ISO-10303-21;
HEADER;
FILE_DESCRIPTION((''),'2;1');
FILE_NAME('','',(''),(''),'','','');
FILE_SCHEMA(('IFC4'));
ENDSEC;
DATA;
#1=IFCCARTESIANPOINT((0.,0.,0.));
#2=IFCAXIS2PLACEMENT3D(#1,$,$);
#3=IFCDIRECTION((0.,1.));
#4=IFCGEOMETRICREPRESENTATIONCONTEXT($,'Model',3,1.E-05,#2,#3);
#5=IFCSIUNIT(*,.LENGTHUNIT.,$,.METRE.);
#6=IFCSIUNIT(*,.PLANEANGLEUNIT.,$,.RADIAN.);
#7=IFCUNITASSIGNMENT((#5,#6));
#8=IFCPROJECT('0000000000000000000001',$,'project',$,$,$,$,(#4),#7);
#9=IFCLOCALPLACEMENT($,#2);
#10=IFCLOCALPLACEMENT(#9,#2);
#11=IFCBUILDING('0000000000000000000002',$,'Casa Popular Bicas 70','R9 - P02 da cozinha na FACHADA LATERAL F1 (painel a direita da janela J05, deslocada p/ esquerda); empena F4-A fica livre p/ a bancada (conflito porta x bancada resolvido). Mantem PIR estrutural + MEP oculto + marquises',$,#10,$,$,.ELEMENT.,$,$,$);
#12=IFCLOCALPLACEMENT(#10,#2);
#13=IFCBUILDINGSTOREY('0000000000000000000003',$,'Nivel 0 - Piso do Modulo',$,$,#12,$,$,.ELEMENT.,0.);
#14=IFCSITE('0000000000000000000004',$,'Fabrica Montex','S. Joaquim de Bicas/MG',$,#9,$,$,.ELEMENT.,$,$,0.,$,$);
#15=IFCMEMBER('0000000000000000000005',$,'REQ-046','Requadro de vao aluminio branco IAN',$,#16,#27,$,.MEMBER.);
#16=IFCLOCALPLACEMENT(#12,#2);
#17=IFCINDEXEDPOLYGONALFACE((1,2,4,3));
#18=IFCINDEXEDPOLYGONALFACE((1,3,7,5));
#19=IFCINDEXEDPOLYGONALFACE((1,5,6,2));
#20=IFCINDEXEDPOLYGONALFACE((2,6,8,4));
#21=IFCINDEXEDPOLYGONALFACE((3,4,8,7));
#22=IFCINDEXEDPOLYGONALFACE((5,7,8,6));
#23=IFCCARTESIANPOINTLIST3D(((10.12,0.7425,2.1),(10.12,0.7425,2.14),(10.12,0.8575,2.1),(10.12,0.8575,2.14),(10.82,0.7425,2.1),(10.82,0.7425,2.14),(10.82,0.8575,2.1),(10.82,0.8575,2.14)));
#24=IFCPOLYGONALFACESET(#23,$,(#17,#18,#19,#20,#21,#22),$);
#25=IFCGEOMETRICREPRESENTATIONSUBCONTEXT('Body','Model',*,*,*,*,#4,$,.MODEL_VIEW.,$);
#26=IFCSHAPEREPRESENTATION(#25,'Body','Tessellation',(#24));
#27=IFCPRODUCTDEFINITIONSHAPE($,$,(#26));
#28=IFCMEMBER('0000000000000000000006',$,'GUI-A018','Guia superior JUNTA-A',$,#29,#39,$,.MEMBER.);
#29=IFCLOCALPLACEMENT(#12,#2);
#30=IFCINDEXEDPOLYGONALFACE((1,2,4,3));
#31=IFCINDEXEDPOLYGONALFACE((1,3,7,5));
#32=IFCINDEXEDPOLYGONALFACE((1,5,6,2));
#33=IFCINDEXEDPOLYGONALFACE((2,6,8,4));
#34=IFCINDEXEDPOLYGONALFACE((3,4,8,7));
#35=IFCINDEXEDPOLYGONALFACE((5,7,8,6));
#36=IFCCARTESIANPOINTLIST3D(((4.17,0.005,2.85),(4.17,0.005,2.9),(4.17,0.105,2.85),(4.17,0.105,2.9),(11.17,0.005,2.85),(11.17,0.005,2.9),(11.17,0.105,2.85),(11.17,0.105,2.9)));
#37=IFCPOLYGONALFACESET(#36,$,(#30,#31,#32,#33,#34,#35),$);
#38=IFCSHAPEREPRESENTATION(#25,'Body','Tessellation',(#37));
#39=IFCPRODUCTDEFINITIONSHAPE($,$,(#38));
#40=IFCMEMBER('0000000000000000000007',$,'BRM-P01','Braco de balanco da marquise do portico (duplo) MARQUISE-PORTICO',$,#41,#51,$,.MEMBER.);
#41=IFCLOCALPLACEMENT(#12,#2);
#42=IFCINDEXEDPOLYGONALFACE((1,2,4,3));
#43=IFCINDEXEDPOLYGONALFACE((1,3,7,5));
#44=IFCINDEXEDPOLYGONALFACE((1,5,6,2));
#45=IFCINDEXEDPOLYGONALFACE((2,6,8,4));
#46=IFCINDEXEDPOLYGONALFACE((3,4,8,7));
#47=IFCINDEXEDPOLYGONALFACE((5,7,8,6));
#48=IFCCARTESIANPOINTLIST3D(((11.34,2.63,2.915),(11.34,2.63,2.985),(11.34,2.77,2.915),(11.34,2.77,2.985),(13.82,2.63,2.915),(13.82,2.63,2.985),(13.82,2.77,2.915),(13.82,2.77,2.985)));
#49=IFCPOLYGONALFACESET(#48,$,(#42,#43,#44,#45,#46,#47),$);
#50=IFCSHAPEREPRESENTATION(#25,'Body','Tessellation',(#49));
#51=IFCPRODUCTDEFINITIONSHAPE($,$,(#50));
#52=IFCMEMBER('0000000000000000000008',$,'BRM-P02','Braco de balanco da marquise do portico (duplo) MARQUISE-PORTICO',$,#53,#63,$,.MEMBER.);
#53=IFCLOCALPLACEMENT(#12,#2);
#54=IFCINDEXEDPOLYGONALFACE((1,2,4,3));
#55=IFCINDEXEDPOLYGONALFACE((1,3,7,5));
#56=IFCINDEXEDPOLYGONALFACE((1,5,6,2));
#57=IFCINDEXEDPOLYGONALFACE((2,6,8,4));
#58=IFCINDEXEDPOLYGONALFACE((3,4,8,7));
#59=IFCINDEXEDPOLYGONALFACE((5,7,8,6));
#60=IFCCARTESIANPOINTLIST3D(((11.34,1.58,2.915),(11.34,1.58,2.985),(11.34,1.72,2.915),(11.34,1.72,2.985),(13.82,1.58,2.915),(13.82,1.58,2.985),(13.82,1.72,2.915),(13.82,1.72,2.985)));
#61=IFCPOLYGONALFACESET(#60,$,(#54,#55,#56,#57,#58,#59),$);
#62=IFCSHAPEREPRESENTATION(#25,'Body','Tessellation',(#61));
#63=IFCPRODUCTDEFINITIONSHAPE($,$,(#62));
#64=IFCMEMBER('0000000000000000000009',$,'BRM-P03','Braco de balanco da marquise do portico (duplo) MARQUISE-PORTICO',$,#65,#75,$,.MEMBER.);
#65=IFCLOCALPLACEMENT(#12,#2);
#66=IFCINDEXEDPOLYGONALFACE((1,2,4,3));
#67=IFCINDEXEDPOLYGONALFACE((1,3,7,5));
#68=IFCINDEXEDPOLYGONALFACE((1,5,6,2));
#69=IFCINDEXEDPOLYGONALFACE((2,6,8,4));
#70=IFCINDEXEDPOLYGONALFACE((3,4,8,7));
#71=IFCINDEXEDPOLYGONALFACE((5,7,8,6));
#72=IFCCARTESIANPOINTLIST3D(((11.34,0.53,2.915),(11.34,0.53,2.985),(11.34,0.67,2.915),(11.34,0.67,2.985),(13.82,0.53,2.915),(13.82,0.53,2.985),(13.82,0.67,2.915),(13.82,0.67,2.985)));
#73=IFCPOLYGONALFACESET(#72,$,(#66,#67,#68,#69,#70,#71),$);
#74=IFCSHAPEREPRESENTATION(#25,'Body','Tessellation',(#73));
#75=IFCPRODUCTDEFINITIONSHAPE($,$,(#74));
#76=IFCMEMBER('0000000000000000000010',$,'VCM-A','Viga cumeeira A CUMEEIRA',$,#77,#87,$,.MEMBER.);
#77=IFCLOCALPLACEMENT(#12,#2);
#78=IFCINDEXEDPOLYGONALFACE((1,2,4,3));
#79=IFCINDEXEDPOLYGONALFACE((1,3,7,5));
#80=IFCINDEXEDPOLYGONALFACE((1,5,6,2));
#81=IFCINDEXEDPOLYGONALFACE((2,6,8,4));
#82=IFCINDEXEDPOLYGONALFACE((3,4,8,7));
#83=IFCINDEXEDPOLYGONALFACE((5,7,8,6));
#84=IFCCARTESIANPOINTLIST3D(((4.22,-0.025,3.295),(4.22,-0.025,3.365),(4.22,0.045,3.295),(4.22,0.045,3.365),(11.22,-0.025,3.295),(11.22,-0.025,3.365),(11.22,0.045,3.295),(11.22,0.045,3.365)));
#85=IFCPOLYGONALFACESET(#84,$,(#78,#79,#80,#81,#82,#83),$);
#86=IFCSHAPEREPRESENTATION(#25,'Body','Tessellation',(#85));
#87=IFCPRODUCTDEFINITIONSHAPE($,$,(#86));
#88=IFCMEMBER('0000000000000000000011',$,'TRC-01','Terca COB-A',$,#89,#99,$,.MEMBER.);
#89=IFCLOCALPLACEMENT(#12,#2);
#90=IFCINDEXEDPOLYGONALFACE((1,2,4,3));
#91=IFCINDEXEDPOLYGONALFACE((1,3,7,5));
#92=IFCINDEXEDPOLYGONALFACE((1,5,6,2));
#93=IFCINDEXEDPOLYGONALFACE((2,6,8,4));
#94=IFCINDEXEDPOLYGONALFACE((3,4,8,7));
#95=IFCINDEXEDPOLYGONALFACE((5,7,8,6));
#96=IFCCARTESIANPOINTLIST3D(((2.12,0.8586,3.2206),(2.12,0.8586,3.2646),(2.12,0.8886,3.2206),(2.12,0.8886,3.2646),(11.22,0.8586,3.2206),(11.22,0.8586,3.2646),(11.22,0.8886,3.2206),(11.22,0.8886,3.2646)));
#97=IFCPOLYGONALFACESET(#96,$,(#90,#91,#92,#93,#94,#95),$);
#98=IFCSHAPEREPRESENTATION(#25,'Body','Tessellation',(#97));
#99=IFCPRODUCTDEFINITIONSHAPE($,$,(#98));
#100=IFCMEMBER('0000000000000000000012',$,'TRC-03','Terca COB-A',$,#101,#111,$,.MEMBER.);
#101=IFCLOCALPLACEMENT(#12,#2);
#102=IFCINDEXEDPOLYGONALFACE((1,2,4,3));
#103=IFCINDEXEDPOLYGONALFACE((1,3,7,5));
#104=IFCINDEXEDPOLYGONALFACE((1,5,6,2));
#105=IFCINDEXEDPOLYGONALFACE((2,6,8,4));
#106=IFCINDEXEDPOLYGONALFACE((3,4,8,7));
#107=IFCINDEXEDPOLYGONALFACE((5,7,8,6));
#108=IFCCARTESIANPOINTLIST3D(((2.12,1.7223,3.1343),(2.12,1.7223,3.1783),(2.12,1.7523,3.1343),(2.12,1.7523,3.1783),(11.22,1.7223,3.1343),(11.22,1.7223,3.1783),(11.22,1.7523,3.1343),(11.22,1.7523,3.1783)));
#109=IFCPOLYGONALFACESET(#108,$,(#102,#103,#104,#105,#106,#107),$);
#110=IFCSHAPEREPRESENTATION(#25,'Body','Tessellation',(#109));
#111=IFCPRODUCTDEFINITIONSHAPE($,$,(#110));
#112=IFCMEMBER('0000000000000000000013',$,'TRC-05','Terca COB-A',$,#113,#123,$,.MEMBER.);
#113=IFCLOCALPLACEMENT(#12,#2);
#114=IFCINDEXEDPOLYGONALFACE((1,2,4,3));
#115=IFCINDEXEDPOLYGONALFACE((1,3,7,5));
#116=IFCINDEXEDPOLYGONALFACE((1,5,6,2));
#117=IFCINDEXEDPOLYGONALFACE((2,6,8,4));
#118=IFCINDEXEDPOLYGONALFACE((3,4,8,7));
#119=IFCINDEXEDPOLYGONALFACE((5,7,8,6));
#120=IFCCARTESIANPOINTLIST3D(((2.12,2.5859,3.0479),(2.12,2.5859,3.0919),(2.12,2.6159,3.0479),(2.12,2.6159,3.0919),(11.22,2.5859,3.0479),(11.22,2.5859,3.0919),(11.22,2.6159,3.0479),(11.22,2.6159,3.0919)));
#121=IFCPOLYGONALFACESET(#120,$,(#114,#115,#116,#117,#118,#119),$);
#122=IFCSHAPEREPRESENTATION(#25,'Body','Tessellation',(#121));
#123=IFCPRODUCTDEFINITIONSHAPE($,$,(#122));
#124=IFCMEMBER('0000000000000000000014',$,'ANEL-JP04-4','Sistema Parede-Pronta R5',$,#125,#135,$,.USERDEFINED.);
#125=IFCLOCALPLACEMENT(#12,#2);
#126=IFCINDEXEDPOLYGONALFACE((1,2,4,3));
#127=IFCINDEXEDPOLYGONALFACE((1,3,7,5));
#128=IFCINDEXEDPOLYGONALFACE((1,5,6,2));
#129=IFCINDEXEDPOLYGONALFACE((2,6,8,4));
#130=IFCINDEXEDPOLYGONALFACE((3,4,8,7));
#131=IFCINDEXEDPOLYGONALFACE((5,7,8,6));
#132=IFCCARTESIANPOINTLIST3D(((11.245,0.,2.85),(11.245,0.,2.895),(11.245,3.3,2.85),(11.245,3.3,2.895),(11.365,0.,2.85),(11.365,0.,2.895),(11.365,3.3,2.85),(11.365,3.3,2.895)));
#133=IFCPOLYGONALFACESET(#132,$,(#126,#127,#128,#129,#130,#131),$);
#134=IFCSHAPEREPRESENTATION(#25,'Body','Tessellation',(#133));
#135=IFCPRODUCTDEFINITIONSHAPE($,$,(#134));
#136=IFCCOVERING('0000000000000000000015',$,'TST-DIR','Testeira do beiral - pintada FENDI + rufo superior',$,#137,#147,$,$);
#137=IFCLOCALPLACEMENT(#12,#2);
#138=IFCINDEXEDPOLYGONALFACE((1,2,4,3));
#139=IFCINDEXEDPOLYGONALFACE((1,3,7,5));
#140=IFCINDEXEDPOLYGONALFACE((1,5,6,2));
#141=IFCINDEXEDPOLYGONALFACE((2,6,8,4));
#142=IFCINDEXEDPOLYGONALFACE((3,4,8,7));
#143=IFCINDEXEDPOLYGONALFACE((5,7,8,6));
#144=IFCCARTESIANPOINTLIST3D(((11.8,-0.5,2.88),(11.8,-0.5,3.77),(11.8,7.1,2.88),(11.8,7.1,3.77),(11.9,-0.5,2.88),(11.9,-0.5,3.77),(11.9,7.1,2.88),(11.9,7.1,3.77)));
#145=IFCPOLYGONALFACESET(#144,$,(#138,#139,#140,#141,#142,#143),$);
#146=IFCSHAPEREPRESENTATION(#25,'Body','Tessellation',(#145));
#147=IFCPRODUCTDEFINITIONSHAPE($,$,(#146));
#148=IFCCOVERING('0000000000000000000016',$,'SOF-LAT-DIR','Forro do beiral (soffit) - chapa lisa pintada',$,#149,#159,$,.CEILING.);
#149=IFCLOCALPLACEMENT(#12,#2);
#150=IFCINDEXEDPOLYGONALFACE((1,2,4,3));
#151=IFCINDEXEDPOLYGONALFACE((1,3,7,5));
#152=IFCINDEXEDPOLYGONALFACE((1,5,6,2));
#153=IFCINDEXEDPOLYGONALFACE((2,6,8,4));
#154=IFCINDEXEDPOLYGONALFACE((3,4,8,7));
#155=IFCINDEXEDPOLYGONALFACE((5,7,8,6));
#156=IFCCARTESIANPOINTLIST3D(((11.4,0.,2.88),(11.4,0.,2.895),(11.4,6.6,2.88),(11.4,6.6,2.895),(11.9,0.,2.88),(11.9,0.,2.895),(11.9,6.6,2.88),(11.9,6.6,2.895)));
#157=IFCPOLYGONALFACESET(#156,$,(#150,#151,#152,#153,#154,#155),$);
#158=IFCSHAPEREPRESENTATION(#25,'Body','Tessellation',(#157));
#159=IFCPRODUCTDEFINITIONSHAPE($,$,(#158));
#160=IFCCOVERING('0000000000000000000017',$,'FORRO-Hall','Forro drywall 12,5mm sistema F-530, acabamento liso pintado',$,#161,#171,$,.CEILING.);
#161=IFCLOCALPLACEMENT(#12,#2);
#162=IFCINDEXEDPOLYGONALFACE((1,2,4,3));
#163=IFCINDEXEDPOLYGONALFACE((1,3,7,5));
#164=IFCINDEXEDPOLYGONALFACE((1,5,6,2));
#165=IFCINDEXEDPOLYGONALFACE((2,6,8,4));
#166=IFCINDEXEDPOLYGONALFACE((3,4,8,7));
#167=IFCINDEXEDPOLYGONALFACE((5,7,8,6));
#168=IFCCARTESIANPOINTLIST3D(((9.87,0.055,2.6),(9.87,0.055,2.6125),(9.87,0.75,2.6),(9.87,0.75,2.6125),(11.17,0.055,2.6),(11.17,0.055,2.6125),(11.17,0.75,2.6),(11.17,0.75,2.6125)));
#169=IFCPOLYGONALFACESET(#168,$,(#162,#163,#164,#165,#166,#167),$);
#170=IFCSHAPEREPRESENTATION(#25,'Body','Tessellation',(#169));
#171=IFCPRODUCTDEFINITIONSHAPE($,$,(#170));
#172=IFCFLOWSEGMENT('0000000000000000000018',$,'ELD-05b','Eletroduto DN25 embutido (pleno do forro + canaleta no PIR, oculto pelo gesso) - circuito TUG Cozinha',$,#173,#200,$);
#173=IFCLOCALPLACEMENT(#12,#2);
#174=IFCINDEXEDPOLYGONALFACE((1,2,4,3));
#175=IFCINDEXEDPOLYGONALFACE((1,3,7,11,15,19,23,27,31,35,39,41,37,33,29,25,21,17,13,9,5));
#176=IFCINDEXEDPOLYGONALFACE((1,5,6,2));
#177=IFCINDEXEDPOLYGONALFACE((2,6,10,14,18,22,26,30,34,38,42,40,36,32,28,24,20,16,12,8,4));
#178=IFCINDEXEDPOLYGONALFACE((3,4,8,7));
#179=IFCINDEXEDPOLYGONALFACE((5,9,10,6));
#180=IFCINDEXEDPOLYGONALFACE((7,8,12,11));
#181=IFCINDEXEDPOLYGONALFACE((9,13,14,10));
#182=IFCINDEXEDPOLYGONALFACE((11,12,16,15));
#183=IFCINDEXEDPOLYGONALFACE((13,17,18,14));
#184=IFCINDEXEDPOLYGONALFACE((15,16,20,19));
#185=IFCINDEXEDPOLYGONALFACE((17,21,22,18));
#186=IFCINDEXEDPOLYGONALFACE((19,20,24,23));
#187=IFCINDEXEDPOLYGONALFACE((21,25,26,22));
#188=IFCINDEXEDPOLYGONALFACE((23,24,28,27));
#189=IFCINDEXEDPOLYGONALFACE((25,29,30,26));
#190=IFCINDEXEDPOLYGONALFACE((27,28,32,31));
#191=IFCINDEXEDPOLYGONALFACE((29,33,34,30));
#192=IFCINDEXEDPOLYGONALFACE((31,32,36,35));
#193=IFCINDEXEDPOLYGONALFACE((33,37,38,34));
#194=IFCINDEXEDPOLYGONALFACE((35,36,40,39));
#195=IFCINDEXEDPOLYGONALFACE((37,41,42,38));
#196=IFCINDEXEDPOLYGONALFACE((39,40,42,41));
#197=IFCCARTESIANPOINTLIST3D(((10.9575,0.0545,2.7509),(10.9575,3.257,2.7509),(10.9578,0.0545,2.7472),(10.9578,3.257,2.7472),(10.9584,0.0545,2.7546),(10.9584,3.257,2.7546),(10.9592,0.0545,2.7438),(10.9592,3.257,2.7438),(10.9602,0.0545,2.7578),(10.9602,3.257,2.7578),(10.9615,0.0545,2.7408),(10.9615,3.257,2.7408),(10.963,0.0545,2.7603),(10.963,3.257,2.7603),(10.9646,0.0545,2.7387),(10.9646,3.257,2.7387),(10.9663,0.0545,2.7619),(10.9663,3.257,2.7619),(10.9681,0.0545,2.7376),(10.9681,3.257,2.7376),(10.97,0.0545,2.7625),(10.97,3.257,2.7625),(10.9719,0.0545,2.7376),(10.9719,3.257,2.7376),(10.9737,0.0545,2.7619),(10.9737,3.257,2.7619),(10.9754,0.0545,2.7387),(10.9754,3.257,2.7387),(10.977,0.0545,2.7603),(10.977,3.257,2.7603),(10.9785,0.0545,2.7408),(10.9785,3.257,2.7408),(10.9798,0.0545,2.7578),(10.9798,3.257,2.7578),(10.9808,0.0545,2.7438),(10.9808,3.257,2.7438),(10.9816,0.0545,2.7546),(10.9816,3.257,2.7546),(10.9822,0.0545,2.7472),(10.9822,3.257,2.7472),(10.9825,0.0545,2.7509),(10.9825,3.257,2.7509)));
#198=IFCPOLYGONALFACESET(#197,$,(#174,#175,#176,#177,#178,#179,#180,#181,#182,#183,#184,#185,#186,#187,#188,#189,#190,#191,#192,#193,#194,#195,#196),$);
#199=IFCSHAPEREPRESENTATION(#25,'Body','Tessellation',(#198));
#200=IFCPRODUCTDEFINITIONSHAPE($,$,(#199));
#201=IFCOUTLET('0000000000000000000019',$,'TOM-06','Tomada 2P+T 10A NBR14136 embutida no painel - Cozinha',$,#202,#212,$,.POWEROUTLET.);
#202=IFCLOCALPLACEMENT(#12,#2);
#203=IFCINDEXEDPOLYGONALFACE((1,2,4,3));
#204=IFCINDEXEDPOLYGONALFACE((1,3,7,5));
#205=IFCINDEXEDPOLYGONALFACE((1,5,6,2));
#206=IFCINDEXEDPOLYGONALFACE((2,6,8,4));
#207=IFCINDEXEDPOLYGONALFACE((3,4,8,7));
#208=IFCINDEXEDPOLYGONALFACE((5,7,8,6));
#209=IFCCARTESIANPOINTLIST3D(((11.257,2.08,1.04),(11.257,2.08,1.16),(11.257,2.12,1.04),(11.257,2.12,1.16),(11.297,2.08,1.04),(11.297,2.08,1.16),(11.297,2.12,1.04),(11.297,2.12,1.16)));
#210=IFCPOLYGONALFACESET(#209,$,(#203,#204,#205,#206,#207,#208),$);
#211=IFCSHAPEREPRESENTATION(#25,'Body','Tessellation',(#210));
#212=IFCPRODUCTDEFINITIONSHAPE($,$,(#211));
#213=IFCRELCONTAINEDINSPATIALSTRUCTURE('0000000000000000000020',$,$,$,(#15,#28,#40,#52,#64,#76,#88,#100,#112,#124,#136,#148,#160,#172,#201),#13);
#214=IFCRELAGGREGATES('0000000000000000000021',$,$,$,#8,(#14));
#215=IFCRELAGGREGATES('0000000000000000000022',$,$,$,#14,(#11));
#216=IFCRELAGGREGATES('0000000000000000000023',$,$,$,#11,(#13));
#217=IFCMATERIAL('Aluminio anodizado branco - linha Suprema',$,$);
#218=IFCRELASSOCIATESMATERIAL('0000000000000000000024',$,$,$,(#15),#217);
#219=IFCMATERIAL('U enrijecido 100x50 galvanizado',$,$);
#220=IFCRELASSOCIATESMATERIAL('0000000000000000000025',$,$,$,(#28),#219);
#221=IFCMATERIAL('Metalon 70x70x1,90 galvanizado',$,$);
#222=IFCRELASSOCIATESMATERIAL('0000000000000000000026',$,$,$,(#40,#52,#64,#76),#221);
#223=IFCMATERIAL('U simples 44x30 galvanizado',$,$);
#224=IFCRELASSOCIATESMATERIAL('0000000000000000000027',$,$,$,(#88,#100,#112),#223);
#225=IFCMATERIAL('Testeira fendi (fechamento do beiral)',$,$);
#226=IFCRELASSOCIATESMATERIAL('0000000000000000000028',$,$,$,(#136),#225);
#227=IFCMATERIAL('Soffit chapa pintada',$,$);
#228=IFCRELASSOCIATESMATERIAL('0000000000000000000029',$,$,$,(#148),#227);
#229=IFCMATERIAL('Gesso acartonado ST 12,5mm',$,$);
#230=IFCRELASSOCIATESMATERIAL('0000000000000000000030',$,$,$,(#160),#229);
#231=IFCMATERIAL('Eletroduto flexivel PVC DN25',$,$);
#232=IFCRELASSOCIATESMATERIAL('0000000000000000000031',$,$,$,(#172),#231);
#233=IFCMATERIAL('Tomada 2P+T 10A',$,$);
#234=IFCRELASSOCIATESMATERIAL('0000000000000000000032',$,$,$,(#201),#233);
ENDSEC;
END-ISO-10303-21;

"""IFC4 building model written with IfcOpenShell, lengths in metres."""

from ifc_helpers import new_model, si_unit, direction, frame, frame_2d, origin, origin_2d, place, context, subcontext, project, spatial, rectangle, circle, extrude, material, element, save


model = new_model("IFC4")

# Units and contexts
model_context = context("Model", 3, precision=1e-05, world=origin(), true_north=direction((0.0, 1.0)))
body_context = subcontext(model_context, "Body", "Model", "MODEL_VIEW")
ifc_project = project(units=[si_unit("LENGTHUNIT", "METRE"), si_unit("PLANEANGLEUNIT", "RADIAN")], contexts=[model_context])

# Site, building, storey
site_placement = place(None, origin())
site = spatial("IfcSite", under=ifc_project, at=site_placement, Name="Fabrica Montex", Description="S. Joaquim de Bicas/MG", CompositionType="ELEMENT", RefElevation=0.0)
building_placement = place(site_placement, origin())
building = spatial("IfcBuilding", under=site, at=building_placement, Name="Casa Popular Bicas 70", Description="R9 - P02 da cozinha na FACHADA LATERAL F1 (painel a direita da janela J05, deslocada p/ esquerda); empena F4-A fica livre p/ a bancada (conflito porta x bancada resolvido). Mantem PIR estrutural + MEP oculto + marquises", CompositionType="ELEMENT")
storey_placement = place(building_placement, origin())
storey = spatial("IfcBuildingStorey", under=building, at=storey_placement, Name="Nivel 0 - Piso do Modulo", CompositionType="ELEMENT", Elevation=0.0)

# Members
ifc_material_1 = material(Name="Aluminio anodizado branco - linha Suprema")
member_1_placement = place(None, frame((10.82, 0.8, 2.12), z_axis=(-1.0, 0.0, 0.0), x_axis=(0.0, 0.0, 1.0)))
element("IfcMember", 1, at=member_1_placement, inside=storey, material=ifc_material_1, Name="REQ-046", Description="Requadro de vao aluminio branco IAN", PredefinedType="MEMBER", context=body_context, shape_type="SweptSolid", body=[
    extrude(rectangle(XDim=0.04, YDim=0.115, at=origin_2d()), origin(), (0.0, 0.0, 1.0), 0.7),
])
ifc_material_2 = material(Name="U enrijecido 100x50 galvanizado")
member_2_placement = place(None, frame((11.17, 0.055, 2.875), z_axis=(-1.0, 0.0, 0.0), x_axis=(0.0, 0.0, 1.0)))
element("IfcMember", 2, at=member_2_placement, inside=storey, material=ifc_material_2, Name="GUI-A018", Description="Guia superior JUNTA-A", PredefinedType="MEMBER", context=body_context, shape_type="SweptSolid", body=[
    extrude(rectangle(XDim=0.05, YDim=0.1, at=origin_2d()), origin(), (0.0, 0.0, 1.0), 7.0),
])
ifc_material_3 = material(Name="Metalon 70x70x1,90 galvanizado")
for number, where, z_axis, x_axis, name in (
    (3, (11.34, 2.7, 2.95), (1.0, 0.0, 0.0), (0.0, 0.0, 1.0), "BRM-P01"),
    (4, (11.34, 1.65, 2.95), (1.0, 0.0, 0.0), (0.0, 0.0, 1.0), "BRM-P02"),
    (5, (11.34, 0.6, 2.95), (1.0, 0.0, 0.0), (0.0, 0.0, 1.0), "BRM-P03"),
):
    element("IfcMember", number, at=place(None, frame(where, z_axis=z_axis, x_axis=x_axis)), inside=storey, material=ifc_material_3, Name=name, Description="Braco de balanco da marquise do portico (duplo) MARQUISE-PORTICO", PredefinedType="MEMBER", context=body_context, shape_type="SweptSolid", body=[
        extrude(rectangle(XDim=0.07, YDim=0.14, at=origin_2d()), origin(), (0.0, 0.0, 1.0), 2.48),
    ])
member_3_placement = place(None, frame((11.22, 0.01, 3.33), z_axis=(-1.0, 0.0, 0.0), x_axis=(0.0, 0.0, 1.0)))
element("IfcMember", 6, at=member_3_placement, inside=storey, material=ifc_material_3, Name="VCM-A", Description="Viga cumeeira A CUMEEIRA", PredefinedType="MEMBER", context=body_context, shape_type="SweptSolid", body=[
    extrude(rectangle(XDim=0.07, YDim=0.07, at=origin_2d()), origin(), (0.0, 0.0, 1.0), 7.0),
])
ifc_material_4 = material(Name="U simples 44x30 galvanizado")
for number, where, z_axis, x_axis, name in (
    (7, (11.22, 0.8736, 3.2426), (-1.0, 0.0, 0.0), (0.0, 0.0, 1.0), "TRC-01"),
    (8, (11.22, 1.7373, 3.1563), (-1.0, 0.0, 0.0), (0.0, 0.0, 1.0), "TRC-03"),
    (9, (11.22, 2.6009, 3.0699), (-1.0, 0.0, 0.0), (0.0, 0.0, 1.0), "TRC-05"),
):
    element("IfcMember", number, at=place(None, frame(where, z_axis=z_axis, x_axis=x_axis)), inside=storey, material=ifc_material_4, Name=name, Description="Terca COB-A", PredefinedType="MEMBER", context=body_context, shape_type="SweptSolid", body=[
        extrude(rectangle(XDim=0.044, YDim=0.03, at=origin_2d()), origin(), (0.0, 0.0, 1.0), 9.1),
    ])
member_4_placement = place(storey_placement, frame((11.305, 1.65, 2.85)))
element("IfcMember", 10, at=member_4_placement, inside=storey, Name="ANEL-JP04-4", Description="Sistema Parede-Pronta R5", PredefinedType="USERDEFINED", context=body_context, shape_type="SweptSolid", body=[
    extrude(rectangle(XDim=0.12, YDim=3.3, at=origin_2d()), origin(), (0.0, 0.0, 1.0), 0.045),
])

# Coverings
ifc_material_5 = material(Name="Testeira fendi (fechamento do beiral)")
covering_1_placement = place(storey_placement, frame((11.85, -0.5, 2.88), x_axis=(0.0, 1.0, 0.0)))
element("IfcCovering", 11, at=covering_1_placement, inside=storey, material=ifc_material_5, Name="TST-DIR", Description="Testeira do beiral - pintada FENDI + rufo superior", context=body_context, shape_type="SweptSolid", body=[
    extrude(rectangle(XDim=7.6, YDim=0.1, at=frame_2d((3.8, 0.0))), origin(), (0.0, 0.0, 1.0), 0.89),
])
ifc_material_6 = material(Name="Soffit chapa pintada")
covering_2_placement = place(storey_placement, frame((11.4, 0.0, 2.88)))
element("IfcCovering", 12, at=covering_2_placement, inside=storey, material=ifc_material_6, Name="SOF-LAT-DIR", Description="Forro do beiral (soffit) - chapa lisa pintada", PredefinedType="CEILING", context=body_context, shape_type="SweptSolid", body=[
    extrude(rectangle(XDim=0.5, YDim=6.6, at=frame_2d((0.25, 3.3))), origin(), (0.0, 0.0, 1.0), 0.015),
])
ifc_material_7 = material(Name="Gesso acartonado ST 12,5mm")
covering_3_placement = place(None, frame((11.17, 0.75, 2.6), z_axis=(0.0, 0.0, 1.0), x_axis=(-1.0, 0.0, 0.0)))
element("IfcCovering", 13, at=covering_3_placement, inside=storey, material=ifc_material_7, Name="FORRO-Hall", Description="Forro drywall 12,5mm sistema F-530, acabamento liso pintado", PredefinedType="CEILING", context=body_context, shape_type="SweptSolid", body=[
    extrude(rectangle(XDim=1.3, YDim=0.695, at=frame_2d((0.65, 0.3475))), origin(), (0.0, 0.0, 1.0), 0.0125),
])

# Flow segment
ifc_material_8 = material(Name="Eletroduto flexivel PVC DN25")
flow_segment_1_placement = place(None, frame((10.97, 0.0545, 2.75), z_axis=(0.0, 1.0, 0.0), x_axis=(0.0, 0.0, 1.0)))
element("IfcFlowSegment", 14, at=flow_segment_1_placement, inside=storey, material=ifc_material_8, Name="ELD-05b", Description="Eletroduto DN25 embutido (pleno do forro + canaleta no PIR, oculto pelo gesso) - circuito TUG Cozinha", context=body_context, shape_type="SweptSolid", body=[
    extrude(circle(Radius=0.0125, at=origin_2d()), origin(), (0.0, 0.0, 1.0), 3.2025),
])

# Outlet
ifc_material_9 = material(Name="Tomada 2P+T 10A")
outlet_1_placement = place(None, frame((11.297, 2.12, 1.04), z_axis=(0.0, 0.0, 1.0), x_axis=(-1.0, 0.0, 0.0)))
element("IfcOutlet", 15, at=outlet_1_placement, inside=storey, material=ifc_material_9, Name="TOM-06", Description="Tomada 2P+T 10A NBR14136 embutida no painel - Cozinha", PredefinedType="POWEROUTLET", context=body_context, shape_type="SweptSolid", body=[
    extrude(rectangle(XDim=0.04, YDim=0.04, at=frame_2d((0.02, 0.02))), origin(), (0.0, 0.0, 1.0), 0.12),
])

save(model, "model.ifc")
